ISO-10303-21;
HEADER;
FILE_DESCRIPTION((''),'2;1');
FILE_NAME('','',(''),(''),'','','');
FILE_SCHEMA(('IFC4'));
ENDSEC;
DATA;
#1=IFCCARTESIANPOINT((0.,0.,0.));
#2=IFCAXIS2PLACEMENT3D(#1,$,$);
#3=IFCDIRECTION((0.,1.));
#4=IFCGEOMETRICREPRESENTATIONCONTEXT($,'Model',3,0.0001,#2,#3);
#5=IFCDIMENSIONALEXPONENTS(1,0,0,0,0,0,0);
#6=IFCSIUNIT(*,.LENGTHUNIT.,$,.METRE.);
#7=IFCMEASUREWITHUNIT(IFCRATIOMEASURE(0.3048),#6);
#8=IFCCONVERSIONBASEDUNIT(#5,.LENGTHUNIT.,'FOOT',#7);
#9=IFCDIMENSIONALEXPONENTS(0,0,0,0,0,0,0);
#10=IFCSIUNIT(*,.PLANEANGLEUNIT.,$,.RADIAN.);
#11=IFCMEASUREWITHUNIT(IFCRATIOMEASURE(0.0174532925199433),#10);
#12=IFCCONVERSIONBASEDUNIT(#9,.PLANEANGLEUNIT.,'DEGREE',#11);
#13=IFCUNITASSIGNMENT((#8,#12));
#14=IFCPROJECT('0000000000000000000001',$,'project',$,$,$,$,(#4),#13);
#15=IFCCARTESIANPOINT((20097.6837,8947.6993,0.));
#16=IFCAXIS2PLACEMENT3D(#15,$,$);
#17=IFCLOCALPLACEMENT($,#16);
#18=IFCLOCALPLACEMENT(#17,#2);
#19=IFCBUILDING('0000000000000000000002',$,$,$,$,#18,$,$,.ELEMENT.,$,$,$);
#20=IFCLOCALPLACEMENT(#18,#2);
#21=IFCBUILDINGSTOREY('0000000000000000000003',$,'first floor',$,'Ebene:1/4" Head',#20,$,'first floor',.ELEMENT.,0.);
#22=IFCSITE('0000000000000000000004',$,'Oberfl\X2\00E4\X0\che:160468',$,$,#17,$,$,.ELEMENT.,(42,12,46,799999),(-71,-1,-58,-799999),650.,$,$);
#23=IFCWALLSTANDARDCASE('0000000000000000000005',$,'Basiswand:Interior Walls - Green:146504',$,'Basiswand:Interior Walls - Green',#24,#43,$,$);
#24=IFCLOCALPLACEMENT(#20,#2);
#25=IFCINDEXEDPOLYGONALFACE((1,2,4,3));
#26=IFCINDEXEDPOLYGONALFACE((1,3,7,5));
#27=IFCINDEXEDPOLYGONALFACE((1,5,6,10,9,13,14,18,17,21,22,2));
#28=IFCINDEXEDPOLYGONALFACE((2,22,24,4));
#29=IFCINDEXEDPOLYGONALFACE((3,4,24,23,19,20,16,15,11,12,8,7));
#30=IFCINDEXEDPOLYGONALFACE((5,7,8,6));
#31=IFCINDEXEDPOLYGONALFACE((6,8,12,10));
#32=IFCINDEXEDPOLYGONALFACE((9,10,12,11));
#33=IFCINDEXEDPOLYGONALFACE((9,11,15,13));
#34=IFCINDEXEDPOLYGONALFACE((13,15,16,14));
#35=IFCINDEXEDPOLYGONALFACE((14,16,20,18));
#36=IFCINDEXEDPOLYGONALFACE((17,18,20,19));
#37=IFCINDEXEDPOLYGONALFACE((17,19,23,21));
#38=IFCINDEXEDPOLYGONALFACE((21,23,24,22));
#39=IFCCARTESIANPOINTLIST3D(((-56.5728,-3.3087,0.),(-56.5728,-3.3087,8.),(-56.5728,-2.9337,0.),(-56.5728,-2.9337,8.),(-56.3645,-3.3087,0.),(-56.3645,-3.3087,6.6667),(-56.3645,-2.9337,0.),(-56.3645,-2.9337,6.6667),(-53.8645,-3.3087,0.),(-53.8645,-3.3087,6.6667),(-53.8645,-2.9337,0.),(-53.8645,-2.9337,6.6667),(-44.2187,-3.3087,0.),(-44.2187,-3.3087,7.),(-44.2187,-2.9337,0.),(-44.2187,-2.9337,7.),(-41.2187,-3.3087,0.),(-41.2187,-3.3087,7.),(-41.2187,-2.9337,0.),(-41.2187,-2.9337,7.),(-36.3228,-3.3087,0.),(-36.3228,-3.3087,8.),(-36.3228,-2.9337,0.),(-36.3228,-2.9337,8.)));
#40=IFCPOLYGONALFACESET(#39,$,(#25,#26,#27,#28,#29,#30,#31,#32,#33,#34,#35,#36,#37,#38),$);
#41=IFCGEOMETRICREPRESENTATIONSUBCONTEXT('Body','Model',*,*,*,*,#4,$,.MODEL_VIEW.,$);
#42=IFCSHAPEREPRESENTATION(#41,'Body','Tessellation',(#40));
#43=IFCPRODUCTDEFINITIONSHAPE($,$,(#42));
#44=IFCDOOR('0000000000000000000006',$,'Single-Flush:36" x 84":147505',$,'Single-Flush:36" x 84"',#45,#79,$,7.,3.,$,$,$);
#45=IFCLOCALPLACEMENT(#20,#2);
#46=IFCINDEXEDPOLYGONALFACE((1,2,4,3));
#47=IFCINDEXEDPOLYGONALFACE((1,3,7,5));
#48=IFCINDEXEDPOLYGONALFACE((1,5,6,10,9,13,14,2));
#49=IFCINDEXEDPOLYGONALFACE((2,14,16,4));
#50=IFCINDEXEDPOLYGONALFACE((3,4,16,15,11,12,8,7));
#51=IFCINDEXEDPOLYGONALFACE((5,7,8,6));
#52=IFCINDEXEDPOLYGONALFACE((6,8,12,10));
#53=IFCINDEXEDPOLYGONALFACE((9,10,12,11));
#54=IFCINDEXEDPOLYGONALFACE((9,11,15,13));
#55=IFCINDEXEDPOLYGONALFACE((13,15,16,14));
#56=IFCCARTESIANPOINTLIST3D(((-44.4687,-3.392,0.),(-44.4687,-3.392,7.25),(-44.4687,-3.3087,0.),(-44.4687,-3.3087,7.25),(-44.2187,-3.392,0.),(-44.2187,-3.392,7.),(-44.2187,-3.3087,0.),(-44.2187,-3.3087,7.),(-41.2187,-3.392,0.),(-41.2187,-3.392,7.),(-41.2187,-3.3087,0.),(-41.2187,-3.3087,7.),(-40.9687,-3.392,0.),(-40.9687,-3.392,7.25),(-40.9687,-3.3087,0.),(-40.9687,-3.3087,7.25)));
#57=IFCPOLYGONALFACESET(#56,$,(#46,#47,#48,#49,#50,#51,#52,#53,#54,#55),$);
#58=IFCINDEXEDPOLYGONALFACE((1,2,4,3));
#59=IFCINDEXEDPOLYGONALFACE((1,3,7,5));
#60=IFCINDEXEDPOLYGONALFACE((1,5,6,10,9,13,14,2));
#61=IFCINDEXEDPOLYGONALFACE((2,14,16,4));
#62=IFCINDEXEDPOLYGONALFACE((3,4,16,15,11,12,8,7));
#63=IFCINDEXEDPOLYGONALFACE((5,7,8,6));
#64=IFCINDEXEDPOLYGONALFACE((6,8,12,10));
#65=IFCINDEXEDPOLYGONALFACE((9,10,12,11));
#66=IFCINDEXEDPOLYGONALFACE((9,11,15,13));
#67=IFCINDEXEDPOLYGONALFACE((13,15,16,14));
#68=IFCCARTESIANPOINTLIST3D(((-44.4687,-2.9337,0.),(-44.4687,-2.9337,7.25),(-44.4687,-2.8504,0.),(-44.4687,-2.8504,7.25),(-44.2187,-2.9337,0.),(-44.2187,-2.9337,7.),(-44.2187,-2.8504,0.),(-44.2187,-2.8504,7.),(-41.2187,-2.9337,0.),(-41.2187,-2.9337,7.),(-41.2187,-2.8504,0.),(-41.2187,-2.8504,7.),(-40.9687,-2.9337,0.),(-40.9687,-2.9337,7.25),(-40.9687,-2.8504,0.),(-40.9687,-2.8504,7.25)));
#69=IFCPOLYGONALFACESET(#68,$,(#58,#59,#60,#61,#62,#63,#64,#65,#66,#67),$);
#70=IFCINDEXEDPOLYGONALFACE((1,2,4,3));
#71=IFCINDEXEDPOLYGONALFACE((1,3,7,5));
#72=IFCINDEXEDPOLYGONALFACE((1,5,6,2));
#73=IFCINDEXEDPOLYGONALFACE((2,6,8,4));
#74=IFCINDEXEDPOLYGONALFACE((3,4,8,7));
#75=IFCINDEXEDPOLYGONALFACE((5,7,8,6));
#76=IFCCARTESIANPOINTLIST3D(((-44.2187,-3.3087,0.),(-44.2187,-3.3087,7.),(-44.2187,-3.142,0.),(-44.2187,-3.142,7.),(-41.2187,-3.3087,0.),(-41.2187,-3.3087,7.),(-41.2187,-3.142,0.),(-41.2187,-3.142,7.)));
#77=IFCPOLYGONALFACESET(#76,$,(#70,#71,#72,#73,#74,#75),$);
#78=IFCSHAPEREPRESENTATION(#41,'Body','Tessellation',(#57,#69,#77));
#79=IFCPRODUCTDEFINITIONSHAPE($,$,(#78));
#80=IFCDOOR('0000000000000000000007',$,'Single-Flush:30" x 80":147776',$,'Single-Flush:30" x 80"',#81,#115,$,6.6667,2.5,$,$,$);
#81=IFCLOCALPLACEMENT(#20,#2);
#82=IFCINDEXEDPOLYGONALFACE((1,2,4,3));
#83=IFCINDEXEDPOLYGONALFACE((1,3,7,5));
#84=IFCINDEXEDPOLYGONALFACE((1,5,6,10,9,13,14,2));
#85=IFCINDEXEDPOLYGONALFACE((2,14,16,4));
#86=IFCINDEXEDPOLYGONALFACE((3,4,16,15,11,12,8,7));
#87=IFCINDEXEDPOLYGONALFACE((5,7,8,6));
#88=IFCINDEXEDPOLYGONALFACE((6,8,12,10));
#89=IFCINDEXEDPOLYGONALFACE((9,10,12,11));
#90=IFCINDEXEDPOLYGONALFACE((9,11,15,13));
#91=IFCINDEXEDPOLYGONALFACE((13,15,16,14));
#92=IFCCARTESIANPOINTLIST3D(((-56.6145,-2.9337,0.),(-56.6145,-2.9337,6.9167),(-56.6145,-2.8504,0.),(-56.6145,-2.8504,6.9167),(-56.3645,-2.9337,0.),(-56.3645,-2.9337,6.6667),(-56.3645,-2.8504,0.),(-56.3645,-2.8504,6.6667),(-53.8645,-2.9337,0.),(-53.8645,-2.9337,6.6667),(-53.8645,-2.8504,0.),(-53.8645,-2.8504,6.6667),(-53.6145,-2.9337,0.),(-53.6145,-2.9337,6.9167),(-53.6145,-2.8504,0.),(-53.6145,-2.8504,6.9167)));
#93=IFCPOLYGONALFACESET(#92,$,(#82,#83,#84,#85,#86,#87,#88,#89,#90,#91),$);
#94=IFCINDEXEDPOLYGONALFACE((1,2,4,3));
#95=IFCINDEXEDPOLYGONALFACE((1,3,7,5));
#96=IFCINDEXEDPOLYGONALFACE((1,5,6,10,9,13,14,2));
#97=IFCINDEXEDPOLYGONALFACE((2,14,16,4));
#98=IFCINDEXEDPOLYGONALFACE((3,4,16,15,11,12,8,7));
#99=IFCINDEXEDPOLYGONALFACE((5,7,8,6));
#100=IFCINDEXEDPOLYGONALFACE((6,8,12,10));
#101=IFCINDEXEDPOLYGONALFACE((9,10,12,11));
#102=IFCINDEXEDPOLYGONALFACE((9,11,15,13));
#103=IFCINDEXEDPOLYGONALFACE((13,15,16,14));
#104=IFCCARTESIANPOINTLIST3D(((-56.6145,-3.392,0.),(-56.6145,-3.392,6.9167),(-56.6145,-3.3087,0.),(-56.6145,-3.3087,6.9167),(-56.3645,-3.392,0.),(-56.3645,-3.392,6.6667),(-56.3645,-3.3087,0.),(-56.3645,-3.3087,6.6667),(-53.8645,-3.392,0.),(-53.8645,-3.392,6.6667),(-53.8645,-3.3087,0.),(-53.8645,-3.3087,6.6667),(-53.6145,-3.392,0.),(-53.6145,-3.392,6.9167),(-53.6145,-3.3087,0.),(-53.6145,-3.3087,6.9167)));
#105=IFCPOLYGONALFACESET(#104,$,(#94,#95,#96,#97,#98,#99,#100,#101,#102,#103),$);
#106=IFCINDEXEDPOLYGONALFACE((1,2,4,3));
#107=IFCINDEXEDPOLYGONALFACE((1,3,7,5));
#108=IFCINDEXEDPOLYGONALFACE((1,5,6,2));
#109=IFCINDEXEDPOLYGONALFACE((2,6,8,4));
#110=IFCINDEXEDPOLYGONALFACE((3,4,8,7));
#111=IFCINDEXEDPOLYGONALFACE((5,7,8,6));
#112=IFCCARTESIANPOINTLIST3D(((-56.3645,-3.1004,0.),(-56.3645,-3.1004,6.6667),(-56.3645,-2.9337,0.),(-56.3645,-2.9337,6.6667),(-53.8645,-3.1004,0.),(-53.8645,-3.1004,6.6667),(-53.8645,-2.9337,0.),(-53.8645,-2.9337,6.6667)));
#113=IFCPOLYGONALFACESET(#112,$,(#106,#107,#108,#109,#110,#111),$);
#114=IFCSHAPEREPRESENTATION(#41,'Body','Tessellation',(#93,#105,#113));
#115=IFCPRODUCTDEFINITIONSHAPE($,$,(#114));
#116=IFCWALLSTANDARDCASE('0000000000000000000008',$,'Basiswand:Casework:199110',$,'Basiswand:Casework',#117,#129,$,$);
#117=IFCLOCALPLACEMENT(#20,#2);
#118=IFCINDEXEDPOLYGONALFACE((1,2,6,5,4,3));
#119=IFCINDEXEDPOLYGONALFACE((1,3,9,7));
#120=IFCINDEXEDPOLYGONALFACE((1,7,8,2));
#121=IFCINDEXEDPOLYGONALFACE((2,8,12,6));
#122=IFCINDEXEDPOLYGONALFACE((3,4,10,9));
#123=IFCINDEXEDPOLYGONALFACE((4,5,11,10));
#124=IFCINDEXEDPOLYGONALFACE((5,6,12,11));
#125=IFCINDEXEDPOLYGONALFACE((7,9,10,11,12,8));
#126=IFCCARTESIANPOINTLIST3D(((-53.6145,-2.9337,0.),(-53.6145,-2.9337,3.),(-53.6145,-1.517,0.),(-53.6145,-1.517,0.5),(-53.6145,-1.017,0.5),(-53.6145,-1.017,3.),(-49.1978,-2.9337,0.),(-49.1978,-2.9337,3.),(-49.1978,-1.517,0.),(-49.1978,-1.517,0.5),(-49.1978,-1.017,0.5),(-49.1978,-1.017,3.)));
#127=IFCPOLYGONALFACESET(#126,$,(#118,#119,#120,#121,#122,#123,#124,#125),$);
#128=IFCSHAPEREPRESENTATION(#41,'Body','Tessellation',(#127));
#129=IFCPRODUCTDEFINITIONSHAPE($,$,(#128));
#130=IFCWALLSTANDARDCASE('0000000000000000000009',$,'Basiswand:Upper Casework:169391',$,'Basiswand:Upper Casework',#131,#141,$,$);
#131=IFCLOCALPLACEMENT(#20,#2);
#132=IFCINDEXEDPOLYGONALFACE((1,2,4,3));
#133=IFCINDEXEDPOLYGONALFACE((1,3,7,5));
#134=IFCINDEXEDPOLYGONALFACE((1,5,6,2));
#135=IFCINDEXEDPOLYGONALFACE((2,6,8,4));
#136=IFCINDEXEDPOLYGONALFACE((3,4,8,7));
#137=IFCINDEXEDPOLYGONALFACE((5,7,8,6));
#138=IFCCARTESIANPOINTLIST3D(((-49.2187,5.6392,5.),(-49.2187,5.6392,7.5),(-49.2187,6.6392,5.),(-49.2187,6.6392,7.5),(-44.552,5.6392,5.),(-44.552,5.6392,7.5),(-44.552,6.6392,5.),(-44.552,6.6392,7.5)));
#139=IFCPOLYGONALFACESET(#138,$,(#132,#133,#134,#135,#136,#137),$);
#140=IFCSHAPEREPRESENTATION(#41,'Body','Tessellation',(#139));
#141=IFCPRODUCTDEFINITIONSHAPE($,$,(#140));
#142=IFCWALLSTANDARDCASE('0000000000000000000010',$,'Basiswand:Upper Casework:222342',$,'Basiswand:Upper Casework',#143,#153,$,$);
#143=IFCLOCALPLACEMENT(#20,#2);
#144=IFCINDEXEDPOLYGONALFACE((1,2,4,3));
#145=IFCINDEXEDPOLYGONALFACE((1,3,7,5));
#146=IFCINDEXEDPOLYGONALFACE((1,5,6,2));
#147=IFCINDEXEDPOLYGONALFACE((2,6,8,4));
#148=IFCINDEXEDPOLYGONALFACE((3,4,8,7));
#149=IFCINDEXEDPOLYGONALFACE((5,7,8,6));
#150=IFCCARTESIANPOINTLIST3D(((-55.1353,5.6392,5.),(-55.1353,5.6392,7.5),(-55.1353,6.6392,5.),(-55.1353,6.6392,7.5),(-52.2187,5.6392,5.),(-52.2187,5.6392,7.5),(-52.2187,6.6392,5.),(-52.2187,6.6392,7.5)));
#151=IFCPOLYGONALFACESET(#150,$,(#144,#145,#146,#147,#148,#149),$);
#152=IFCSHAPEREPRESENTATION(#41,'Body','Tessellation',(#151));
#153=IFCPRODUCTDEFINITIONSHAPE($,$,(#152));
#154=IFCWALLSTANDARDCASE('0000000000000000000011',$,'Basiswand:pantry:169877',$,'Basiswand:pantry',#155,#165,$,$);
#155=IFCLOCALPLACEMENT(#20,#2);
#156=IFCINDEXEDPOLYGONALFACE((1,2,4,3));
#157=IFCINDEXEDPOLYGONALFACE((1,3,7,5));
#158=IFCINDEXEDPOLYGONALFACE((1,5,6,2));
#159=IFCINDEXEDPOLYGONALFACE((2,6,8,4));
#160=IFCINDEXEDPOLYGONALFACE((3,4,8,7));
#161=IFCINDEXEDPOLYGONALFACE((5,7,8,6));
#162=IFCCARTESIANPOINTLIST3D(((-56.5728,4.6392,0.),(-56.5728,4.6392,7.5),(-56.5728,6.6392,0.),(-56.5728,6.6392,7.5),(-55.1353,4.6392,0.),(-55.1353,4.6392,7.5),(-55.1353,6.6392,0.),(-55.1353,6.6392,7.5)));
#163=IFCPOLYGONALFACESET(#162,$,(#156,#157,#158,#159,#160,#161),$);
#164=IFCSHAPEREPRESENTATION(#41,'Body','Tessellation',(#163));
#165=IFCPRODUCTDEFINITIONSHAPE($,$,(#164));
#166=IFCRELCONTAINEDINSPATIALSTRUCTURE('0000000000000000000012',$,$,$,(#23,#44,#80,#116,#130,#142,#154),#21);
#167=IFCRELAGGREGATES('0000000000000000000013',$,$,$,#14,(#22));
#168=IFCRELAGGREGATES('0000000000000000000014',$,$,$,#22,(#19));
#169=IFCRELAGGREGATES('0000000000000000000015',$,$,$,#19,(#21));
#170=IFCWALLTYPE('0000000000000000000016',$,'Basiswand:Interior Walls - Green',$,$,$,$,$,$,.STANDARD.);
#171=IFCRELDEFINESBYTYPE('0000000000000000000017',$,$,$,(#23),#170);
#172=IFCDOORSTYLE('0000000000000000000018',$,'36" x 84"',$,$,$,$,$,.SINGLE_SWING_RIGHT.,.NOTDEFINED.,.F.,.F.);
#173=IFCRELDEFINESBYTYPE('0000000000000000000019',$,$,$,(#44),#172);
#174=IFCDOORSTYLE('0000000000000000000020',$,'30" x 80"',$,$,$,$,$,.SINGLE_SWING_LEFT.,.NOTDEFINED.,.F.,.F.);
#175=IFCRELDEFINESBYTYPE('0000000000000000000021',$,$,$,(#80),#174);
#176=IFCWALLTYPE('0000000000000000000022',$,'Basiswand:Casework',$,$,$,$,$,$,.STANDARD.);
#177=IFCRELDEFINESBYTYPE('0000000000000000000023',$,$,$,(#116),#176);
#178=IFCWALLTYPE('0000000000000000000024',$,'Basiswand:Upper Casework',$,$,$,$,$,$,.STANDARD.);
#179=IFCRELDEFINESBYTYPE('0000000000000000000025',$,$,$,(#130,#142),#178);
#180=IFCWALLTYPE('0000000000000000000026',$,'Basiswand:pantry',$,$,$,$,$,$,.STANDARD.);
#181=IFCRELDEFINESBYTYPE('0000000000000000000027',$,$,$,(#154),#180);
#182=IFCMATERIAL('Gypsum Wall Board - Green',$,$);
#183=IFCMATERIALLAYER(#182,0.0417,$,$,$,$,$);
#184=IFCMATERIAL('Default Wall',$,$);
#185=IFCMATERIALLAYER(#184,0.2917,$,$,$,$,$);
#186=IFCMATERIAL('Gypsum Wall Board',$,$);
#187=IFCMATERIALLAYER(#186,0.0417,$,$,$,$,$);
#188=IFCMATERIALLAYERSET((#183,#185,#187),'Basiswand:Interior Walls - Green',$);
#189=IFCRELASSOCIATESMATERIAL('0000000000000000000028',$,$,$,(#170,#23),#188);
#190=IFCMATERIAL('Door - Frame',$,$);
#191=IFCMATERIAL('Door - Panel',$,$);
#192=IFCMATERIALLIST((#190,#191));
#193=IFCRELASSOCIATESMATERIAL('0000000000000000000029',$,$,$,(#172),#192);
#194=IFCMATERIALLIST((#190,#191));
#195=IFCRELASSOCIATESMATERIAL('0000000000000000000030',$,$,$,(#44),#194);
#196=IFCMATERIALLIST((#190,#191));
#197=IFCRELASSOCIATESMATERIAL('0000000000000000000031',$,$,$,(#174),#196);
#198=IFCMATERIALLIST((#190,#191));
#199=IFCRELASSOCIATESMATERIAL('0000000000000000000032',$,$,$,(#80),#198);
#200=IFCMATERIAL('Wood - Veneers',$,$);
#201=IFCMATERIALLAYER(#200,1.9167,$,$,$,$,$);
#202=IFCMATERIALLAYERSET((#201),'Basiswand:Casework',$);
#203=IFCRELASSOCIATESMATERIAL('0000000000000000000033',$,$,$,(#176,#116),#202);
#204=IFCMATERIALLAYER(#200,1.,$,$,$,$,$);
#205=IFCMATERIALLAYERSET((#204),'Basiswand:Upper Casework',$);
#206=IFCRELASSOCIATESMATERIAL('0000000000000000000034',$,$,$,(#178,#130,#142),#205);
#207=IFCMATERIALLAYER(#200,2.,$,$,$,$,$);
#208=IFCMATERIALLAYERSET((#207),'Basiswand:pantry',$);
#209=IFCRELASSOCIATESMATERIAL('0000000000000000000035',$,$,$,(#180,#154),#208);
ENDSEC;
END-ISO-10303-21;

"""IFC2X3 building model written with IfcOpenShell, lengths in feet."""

from ifc_helpers import new_model, entity, si_unit, converted_unit, direction, frame, frame_2d, origin, origin_2d_with_axis, place, context, subcontext, project, spatial, polyline, rectangle, outline, extrude, source, transform, mapped, material, material_list, layer, layer_set, layer_usage, type_object, type_shapes, element, fill, save


model = new_model("IFC2X3")

# Units and contexts
model_context = context("Model", 3, precision=0.0001, world=origin(), true_north=direction((0.0, 1.0)))
body_context = subcontext(model_context, "Body", "Model", "MODEL_VIEW")
ifc_project = project(units=[converted_unit("LENGTHUNIT", "FOOT", entity("IfcRatioMeasure", 0.3048), si_unit("LENGTHUNIT", "METRE"), dimensions=[1, 0, 0, 0, 0, 0, 0]), converted_unit("PLANEANGLEUNIT", "DEGREE", entity("IfcRatioMeasure", 0.0174532925199433), si_unit("PLANEANGLEUNIT", "RADIAN"), dimensions=[0, 0, 0, 0, 0, 0, 0])], contexts=[model_context])

# Site, building, storey
site_placement = place(None, frame((20097.6837, 8947.6993, 0.0)))
site = spatial("IfcSite", under=ifc_project, at=site_placement, Name="Oberfläche:160468", CompositionType="ELEMENT", RefLatitude=(42, 12, 46, 799999), RefLongitude=(-71, -1, -58, -799999), RefElevation=650.0)
building_placement = place(site_placement, origin())
building = spatial("IfcBuilding", under=site, at=building_placement, CompositionType="ELEMENT")
storey_placement = place(building_placement, origin())
storey = spatial("IfcBuildingStorey", under=building, at=storey_placement, Name="first floor", ObjectType="Ebene:1/4\" Head", LongName="first floor", CompositionType="ELEMENT", Elevation=0.0)

# Shared definitions
ifc_material_1 = material(Name="Gypsum Wall Board")
ifc_material_2 = material(Name="Door - Frame")
ifc_material_3 = material(Name="Door - Panel")

# Shared definitions
ifc_material_4 = material(Name="Default Wall")

# Wall, openings, doors
ifc_material_5 = material(Name="Gypsum Wall Board - Green")
ifc_layer_1 = layer(ifc_material_5, 0.0417)
ifc_layer_2 = layer(ifc_material_4, 0.2917)
ifc_layer_3 = layer(ifc_material_1, 0.0417)
ifc_layer_set_1 = layer_set([ifc_layer_1, ifc_layer_2, ifc_layer_3], Name="Basiswand:Interior Walls - Green")
ifc_layer_usage_1 = layer_usage(ifc_layer_set_1, "AXIS2", "NEGATIVE", 0.1875)
wall_type_1 = type_object("IfcWallType", Name="Basiswand:Interior Walls - Green", PredefinedType="STANDARD", material=ifc_layer_set_1)
wall_1_placement = place(storey_placement, frame((-56.5728, -3.1212, 0.0)))
wall_1 = element("IfcWallStandardCase", 1, at=wall_1_placement, inside=storey, type_object=wall_type_1, material=ifc_layer_usage_1, Name="Basiswand:Interior Walls - Green:146504", ObjectType="Basiswand:Interior Walls - Green", context=body_context, shape_type="SweptSolid", body=[
    extrude(rectangle(XDim=20.25, YDim=0.375, at=frame_2d((10.125, 0.0), x_axis=(-1.0, 0.0))), origin(), (0.0, 0.0, 1.0), 8.0),
])
opening_1_placement = place(wall_1_placement, frame((15.3542, 0.1875, 0.0)))
opening_1 = element("IfcOpeningElement", 2, at=opening_1_placement, cuts=wall_1, ObjectType="Opening", context=body_context, shape_type="SweptSolid", body=[
    extrude(rectangle(XDim=3.0, YDim=7.0, at=frame_2d((3.5, 1.5), x_axis=(0.0, 1.0))), frame((0.0, 0.0, 0.0), z_axis=(0.0, -1.0, 0.0), x_axis=(0.0, 0.0, 1.0)), (0.0, 0.0, 1.0), 0.375),
])
opening_2_placement = place(wall_1_placement, frame((0.2083, -0.1875, 0.0)))
opening_2 = element("IfcOpeningElement", 3, at=opening_2_placement, cuts=wall_1, ObjectType="Opening", context=body_context, shape_type="SweptSolid", body=[
    extrude(rectangle(XDim=2.5, YDim=6.6667, at=frame_2d((3.3333, 1.25), x_axis=(0.0, -1.0))), frame((0.0, 0.0, 0.0), z_axis=(0.0, 1.0, 0.0), x_axis=(0.0, 0.0, 1.0)), (0.0, 0.0, 1.0), 0.375),
])
ifc_material_list_1 = material_list([ifc_material_2, ifc_material_3])
ifc_material_list_2 = material_list([ifc_material_2, ifc_material_3])
door_style_1 = type_object("IfcDoorStyle", Name="36\" x 84\"", ConstructionType="NOTDEFINED", OperationType="SINGLE_SWING_RIGHT", ParameterTakesPrecedence=False, Sizeable=False, material=ifc_material_list_2)
shared_shape_1 = source(origin(), body_context, "Body", "SweptSolid", [
    extrude(outline(polyline([(-1.75, -3.6875), (1.75, -3.6875), (1.75, 3.5625), (1.5, 3.5625), (1.5, -3.4375), (-1.5, -3.4375), (-1.5, 3.5625), (-1.75, 3.5625), (-1.75, -3.6875)])), frame((1.5, 0.375, 3.5625), z_axis=(0.0, 1.0, 0.0), x_axis=(1.0, 0.0, 0.0)), (0.0, 0.0, 1.0), 0.0833),
    extrude(outline(polyline([(-3.6875, -1.75), (3.5625, -1.75), (3.5625, -1.5), (-3.4375, -1.5), (-3.4375, 1.5), (3.5625, 1.5), (3.5625, 1.75), (-3.6875, 1.75), (-3.6875, -1.75)])), frame((1.5, -0.0833, 3.5625), z_axis=(0.0, 1.0, 0.0), x_axis=(0.0, 0.0, -1.0)), (0.0, 0.0, 1.0), 0.0833),
    extrude(rectangle(XDim=0.1667, YDim=3.0, at=origin_2d_with_axis()), frame((1.5, 0.2917, 0.0), z_axis=(0.0, 0.0, 1.0), x_axis=(0.0, 1.0, 0.0)), (0.0, 0.0, 1.0), 7.0),
])
type_shapes(door_style_1, [shared_shape_1])
door_1_placement = place(opening_1_placement, frame((0.0, 0.0, 0.0), z_axis=(0.0, 0.0, 1.0), x_axis=(-1.0, 0.0, 0.0)))
door_1 = element("IfcDoor", 4, at=door_1_placement, inside=storey, type_object=door_style_1, material=ifc_material_list_1, Name="Single-Flush:36\" x 84\":147505", ObjectType="Single-Flush:36\" x 84\"", OverallHeight=7.0, OverallWidth=3.0, context=body_context, shape_type="MappedRepresentation", body=[
    mapped(shared_shape_1, transform((0.0, 0.0, 0.0), scale=1.0)),
])
fill(opening_1, door_1)
ifc_material_list_3 = material_list([ifc_material_2, ifc_material_3])
ifc_material_list_4 = material_list([ifc_material_2, ifc_material_3])
door_style_2 = type_object("IfcDoorStyle", Name="30\" x 80\"", ConstructionType="NOTDEFINED", OperationType="SINGLE_SWING_LEFT", ParameterTakesPrecedence=False, Sizeable=False, material=ifc_material_list_4)
shared_shape_2 = source(origin(), body_context, "Body", "SweptSolid", [
    extrude(outline(polyline([(-1.5, -3.5208), (1.5, -3.5208), (1.5, 3.3958), (1.25, 3.3958), (1.25, -3.2708), (-1.25, -3.2708), (-1.25, 3.3958), (-1.5, 3.3958), (-1.5, -3.5208)])), frame((1.25, 0.4583, 3.3958), z_axis=(0.0, -1.0, 0.0), x_axis=(-1.0, 0.0, 0.0)), (0.0, 0.0, 1.0), 0.0833),
    extrude(outline(polyline([(-3.5208, -1.5), (3.3958, -1.5), (3.3958, -1.25), (-3.2708, -1.25), (-3.2708, 1.25), (3.3958, 1.25), (3.3958, 1.5), (-3.5208, 1.5), (-3.5208, -1.5)])), frame((1.25, 0.0, 3.3958), z_axis=(0.0, -1.0, 0.0), x_axis=(0.0, 0.0, -1.0)), (0.0, 0.0, 1.0), 0.0833),
    extrude(rectangle(XDim=2.5, YDim=0.1667, at=origin_2d_with_axis()), frame((1.25, 0.2917, 0.0)), (0.0, 0.0, 1.0), 6.6667),
])
type_shapes(door_style_2, [shared_shape_2])
door_2_placement = place(opening_2_placement, origin())
door_2 = element("IfcDoor", 5, at=door_2_placement, inside=storey, type_object=door_style_2, material=ifc_material_list_3, Name="Single-Flush:30\" x 80\":147776", ObjectType="Single-Flush:30\" x 80\"", OverallHeight=6.6667, OverallWidth=2.5, context=body_context, shape_type="MappedRepresentation", body=[
    mapped(shared_shape_2, transform((0.0, 0.0, 0.0), scale=1.0)),
])
fill(opening_2, door_2)

# Wall, opening
ifc_material_6 = material(Name="Wood - Veneers")
ifc_layer_4 = layer(ifc_material_6, 1.9167)
ifc_layer_set_2 = layer_set([ifc_layer_4], Name="Basiswand:Casework")
ifc_layer_usage_2 = layer_usage(ifc_layer_set_2, "AXIS2", "NEGATIVE", 0.9583)
wall_type_2 = type_object("IfcWallType", Name="Basiswand:Casework", PredefinedType="STANDARD", material=ifc_layer_set_2)
wall_2_placement = place(storey_placement, frame((-49.1978, -1.9754, 0.0), z_axis=(0.0, 0.0, 1.0), x_axis=(-1.0, 0.0, 0.0)))
wall_2 = element("IfcWallStandardCase", 6, at=wall_2_placement, inside=storey, type_object=wall_type_2, material=ifc_layer_usage_2, Name="Basiswand:Casework:199110", ObjectType="Basiswand:Casework", context=body_context, shape_type="SweptSolid", body=[
    extrude(rectangle(XDim=4.4167, YDim=1.9167, at=frame_2d((2.2083, 0.0), x_axis=(-1.0, 0.0))), origin(), (0.0, 0.0, 1.0), 3.0),
])
opening_3_placement = place(wall_2_placement, origin())
element("IfcOpeningElement", 7, at=opening_3_placement, cuts=wall_2, ObjectType="Recess", context=body_context, shape_type="SweptSolid", body=[
    extrude(rectangle(XDim=0.5, YDim=4.4167, at=frame_2d((0.0, 0.0), x_axis=(0.0, 1.0))), frame((2.2083, -0.9583, 0.25), z_axis=(0.0, 1.0, 0.0), x_axis=(1.0, 0.0, 0.0)), (0.0, 0.0, 1.0), 0.5),
])

# Walls
ifc_layer_5 = layer(ifc_material_6, 1.0)
ifc_layer_set_3 = layer_set([ifc_layer_5], Name="Basiswand:Upper Casework")
ifc_layer_usage_3 = layer_usage(ifc_layer_set_3, "AXIS2", "POSITIVE", -0.5)
wall_type_3 = type_object("IfcWallType", Name="Basiswand:Upper Casework", PredefinedType="STANDARD", material=ifc_layer_set_3)
wall_3_placement = place(storey_placement, frame((-49.2187, 6.1392, 5.0)))
element("IfcWallStandardCase", 8, at=wall_3_placement, inside=storey, type_object=wall_type_3, material=ifc_layer_usage_3, Name="Basiswand:Upper Casework:169391", ObjectType="Basiswand:Upper Casework", context=body_context, shape_type="SweptSolid", body=[
    extrude(rectangle(XDim=4.6667, YDim=1.0, at=frame_2d((2.3333, 0.0), x_axis=(-1.0, 0.0))), origin(), (0.0, 0.0, 1.0), 2.5),
])
ifc_layer_usage_4 = layer_usage(ifc_layer_set_3, "AXIS2", "POSITIVE", -0.5)
wall_4_placement = place(storey_placement, frame((-55.1353, 6.1392, 5.0)))
element("IfcWallStandardCase", 9, at=wall_4_placement, inside=storey, type_object=wall_type_3, material=ifc_layer_usage_4, Name="Basiswand:Upper Casework:222342", ObjectType="Basiswand:Upper Casework", context=body_context, shape_type="SweptSolid", body=[
    extrude(rectangle(XDim=2.9167, YDim=1.0, at=frame_2d((1.4583, 0.0), x_axis=(-1.0, 0.0))), origin(), (0.0, 0.0, 1.0), 2.5),
])
ifc_layer_6 = layer(ifc_material_6, 2.0)
ifc_layer_set_4 = layer_set([ifc_layer_6], Name="Basiswand:pantry")
ifc_layer_usage_5 = layer_usage(ifc_layer_set_4, "AXIS2", "POSITIVE", -1.0)
wall_type_4 = type_object("IfcWallType", Name="Basiswand:pantry", PredefinedType="STANDARD", material=ifc_layer_set_4)
wall_5_placement = place(storey_placement, frame((-56.5728, 5.6392, 0.0)))
element("IfcWallStandardCase", 10, at=wall_5_placement, inside=storey, type_object=wall_type_4, material=ifc_layer_usage_5, Name="Basiswand:pantry:169877", ObjectType="Basiswand:pantry", context=body_context, shape_type="SweptSolid", body=[
    extrude(rectangle(XDim=1.4375, YDim=2.0, at=frame_2d((0.7188, 0.0), x_axis=(-1.0, 0.0))), origin(), (0.0, 0.0, 1.0), 7.5),
])

save(model, "model.ifc")
